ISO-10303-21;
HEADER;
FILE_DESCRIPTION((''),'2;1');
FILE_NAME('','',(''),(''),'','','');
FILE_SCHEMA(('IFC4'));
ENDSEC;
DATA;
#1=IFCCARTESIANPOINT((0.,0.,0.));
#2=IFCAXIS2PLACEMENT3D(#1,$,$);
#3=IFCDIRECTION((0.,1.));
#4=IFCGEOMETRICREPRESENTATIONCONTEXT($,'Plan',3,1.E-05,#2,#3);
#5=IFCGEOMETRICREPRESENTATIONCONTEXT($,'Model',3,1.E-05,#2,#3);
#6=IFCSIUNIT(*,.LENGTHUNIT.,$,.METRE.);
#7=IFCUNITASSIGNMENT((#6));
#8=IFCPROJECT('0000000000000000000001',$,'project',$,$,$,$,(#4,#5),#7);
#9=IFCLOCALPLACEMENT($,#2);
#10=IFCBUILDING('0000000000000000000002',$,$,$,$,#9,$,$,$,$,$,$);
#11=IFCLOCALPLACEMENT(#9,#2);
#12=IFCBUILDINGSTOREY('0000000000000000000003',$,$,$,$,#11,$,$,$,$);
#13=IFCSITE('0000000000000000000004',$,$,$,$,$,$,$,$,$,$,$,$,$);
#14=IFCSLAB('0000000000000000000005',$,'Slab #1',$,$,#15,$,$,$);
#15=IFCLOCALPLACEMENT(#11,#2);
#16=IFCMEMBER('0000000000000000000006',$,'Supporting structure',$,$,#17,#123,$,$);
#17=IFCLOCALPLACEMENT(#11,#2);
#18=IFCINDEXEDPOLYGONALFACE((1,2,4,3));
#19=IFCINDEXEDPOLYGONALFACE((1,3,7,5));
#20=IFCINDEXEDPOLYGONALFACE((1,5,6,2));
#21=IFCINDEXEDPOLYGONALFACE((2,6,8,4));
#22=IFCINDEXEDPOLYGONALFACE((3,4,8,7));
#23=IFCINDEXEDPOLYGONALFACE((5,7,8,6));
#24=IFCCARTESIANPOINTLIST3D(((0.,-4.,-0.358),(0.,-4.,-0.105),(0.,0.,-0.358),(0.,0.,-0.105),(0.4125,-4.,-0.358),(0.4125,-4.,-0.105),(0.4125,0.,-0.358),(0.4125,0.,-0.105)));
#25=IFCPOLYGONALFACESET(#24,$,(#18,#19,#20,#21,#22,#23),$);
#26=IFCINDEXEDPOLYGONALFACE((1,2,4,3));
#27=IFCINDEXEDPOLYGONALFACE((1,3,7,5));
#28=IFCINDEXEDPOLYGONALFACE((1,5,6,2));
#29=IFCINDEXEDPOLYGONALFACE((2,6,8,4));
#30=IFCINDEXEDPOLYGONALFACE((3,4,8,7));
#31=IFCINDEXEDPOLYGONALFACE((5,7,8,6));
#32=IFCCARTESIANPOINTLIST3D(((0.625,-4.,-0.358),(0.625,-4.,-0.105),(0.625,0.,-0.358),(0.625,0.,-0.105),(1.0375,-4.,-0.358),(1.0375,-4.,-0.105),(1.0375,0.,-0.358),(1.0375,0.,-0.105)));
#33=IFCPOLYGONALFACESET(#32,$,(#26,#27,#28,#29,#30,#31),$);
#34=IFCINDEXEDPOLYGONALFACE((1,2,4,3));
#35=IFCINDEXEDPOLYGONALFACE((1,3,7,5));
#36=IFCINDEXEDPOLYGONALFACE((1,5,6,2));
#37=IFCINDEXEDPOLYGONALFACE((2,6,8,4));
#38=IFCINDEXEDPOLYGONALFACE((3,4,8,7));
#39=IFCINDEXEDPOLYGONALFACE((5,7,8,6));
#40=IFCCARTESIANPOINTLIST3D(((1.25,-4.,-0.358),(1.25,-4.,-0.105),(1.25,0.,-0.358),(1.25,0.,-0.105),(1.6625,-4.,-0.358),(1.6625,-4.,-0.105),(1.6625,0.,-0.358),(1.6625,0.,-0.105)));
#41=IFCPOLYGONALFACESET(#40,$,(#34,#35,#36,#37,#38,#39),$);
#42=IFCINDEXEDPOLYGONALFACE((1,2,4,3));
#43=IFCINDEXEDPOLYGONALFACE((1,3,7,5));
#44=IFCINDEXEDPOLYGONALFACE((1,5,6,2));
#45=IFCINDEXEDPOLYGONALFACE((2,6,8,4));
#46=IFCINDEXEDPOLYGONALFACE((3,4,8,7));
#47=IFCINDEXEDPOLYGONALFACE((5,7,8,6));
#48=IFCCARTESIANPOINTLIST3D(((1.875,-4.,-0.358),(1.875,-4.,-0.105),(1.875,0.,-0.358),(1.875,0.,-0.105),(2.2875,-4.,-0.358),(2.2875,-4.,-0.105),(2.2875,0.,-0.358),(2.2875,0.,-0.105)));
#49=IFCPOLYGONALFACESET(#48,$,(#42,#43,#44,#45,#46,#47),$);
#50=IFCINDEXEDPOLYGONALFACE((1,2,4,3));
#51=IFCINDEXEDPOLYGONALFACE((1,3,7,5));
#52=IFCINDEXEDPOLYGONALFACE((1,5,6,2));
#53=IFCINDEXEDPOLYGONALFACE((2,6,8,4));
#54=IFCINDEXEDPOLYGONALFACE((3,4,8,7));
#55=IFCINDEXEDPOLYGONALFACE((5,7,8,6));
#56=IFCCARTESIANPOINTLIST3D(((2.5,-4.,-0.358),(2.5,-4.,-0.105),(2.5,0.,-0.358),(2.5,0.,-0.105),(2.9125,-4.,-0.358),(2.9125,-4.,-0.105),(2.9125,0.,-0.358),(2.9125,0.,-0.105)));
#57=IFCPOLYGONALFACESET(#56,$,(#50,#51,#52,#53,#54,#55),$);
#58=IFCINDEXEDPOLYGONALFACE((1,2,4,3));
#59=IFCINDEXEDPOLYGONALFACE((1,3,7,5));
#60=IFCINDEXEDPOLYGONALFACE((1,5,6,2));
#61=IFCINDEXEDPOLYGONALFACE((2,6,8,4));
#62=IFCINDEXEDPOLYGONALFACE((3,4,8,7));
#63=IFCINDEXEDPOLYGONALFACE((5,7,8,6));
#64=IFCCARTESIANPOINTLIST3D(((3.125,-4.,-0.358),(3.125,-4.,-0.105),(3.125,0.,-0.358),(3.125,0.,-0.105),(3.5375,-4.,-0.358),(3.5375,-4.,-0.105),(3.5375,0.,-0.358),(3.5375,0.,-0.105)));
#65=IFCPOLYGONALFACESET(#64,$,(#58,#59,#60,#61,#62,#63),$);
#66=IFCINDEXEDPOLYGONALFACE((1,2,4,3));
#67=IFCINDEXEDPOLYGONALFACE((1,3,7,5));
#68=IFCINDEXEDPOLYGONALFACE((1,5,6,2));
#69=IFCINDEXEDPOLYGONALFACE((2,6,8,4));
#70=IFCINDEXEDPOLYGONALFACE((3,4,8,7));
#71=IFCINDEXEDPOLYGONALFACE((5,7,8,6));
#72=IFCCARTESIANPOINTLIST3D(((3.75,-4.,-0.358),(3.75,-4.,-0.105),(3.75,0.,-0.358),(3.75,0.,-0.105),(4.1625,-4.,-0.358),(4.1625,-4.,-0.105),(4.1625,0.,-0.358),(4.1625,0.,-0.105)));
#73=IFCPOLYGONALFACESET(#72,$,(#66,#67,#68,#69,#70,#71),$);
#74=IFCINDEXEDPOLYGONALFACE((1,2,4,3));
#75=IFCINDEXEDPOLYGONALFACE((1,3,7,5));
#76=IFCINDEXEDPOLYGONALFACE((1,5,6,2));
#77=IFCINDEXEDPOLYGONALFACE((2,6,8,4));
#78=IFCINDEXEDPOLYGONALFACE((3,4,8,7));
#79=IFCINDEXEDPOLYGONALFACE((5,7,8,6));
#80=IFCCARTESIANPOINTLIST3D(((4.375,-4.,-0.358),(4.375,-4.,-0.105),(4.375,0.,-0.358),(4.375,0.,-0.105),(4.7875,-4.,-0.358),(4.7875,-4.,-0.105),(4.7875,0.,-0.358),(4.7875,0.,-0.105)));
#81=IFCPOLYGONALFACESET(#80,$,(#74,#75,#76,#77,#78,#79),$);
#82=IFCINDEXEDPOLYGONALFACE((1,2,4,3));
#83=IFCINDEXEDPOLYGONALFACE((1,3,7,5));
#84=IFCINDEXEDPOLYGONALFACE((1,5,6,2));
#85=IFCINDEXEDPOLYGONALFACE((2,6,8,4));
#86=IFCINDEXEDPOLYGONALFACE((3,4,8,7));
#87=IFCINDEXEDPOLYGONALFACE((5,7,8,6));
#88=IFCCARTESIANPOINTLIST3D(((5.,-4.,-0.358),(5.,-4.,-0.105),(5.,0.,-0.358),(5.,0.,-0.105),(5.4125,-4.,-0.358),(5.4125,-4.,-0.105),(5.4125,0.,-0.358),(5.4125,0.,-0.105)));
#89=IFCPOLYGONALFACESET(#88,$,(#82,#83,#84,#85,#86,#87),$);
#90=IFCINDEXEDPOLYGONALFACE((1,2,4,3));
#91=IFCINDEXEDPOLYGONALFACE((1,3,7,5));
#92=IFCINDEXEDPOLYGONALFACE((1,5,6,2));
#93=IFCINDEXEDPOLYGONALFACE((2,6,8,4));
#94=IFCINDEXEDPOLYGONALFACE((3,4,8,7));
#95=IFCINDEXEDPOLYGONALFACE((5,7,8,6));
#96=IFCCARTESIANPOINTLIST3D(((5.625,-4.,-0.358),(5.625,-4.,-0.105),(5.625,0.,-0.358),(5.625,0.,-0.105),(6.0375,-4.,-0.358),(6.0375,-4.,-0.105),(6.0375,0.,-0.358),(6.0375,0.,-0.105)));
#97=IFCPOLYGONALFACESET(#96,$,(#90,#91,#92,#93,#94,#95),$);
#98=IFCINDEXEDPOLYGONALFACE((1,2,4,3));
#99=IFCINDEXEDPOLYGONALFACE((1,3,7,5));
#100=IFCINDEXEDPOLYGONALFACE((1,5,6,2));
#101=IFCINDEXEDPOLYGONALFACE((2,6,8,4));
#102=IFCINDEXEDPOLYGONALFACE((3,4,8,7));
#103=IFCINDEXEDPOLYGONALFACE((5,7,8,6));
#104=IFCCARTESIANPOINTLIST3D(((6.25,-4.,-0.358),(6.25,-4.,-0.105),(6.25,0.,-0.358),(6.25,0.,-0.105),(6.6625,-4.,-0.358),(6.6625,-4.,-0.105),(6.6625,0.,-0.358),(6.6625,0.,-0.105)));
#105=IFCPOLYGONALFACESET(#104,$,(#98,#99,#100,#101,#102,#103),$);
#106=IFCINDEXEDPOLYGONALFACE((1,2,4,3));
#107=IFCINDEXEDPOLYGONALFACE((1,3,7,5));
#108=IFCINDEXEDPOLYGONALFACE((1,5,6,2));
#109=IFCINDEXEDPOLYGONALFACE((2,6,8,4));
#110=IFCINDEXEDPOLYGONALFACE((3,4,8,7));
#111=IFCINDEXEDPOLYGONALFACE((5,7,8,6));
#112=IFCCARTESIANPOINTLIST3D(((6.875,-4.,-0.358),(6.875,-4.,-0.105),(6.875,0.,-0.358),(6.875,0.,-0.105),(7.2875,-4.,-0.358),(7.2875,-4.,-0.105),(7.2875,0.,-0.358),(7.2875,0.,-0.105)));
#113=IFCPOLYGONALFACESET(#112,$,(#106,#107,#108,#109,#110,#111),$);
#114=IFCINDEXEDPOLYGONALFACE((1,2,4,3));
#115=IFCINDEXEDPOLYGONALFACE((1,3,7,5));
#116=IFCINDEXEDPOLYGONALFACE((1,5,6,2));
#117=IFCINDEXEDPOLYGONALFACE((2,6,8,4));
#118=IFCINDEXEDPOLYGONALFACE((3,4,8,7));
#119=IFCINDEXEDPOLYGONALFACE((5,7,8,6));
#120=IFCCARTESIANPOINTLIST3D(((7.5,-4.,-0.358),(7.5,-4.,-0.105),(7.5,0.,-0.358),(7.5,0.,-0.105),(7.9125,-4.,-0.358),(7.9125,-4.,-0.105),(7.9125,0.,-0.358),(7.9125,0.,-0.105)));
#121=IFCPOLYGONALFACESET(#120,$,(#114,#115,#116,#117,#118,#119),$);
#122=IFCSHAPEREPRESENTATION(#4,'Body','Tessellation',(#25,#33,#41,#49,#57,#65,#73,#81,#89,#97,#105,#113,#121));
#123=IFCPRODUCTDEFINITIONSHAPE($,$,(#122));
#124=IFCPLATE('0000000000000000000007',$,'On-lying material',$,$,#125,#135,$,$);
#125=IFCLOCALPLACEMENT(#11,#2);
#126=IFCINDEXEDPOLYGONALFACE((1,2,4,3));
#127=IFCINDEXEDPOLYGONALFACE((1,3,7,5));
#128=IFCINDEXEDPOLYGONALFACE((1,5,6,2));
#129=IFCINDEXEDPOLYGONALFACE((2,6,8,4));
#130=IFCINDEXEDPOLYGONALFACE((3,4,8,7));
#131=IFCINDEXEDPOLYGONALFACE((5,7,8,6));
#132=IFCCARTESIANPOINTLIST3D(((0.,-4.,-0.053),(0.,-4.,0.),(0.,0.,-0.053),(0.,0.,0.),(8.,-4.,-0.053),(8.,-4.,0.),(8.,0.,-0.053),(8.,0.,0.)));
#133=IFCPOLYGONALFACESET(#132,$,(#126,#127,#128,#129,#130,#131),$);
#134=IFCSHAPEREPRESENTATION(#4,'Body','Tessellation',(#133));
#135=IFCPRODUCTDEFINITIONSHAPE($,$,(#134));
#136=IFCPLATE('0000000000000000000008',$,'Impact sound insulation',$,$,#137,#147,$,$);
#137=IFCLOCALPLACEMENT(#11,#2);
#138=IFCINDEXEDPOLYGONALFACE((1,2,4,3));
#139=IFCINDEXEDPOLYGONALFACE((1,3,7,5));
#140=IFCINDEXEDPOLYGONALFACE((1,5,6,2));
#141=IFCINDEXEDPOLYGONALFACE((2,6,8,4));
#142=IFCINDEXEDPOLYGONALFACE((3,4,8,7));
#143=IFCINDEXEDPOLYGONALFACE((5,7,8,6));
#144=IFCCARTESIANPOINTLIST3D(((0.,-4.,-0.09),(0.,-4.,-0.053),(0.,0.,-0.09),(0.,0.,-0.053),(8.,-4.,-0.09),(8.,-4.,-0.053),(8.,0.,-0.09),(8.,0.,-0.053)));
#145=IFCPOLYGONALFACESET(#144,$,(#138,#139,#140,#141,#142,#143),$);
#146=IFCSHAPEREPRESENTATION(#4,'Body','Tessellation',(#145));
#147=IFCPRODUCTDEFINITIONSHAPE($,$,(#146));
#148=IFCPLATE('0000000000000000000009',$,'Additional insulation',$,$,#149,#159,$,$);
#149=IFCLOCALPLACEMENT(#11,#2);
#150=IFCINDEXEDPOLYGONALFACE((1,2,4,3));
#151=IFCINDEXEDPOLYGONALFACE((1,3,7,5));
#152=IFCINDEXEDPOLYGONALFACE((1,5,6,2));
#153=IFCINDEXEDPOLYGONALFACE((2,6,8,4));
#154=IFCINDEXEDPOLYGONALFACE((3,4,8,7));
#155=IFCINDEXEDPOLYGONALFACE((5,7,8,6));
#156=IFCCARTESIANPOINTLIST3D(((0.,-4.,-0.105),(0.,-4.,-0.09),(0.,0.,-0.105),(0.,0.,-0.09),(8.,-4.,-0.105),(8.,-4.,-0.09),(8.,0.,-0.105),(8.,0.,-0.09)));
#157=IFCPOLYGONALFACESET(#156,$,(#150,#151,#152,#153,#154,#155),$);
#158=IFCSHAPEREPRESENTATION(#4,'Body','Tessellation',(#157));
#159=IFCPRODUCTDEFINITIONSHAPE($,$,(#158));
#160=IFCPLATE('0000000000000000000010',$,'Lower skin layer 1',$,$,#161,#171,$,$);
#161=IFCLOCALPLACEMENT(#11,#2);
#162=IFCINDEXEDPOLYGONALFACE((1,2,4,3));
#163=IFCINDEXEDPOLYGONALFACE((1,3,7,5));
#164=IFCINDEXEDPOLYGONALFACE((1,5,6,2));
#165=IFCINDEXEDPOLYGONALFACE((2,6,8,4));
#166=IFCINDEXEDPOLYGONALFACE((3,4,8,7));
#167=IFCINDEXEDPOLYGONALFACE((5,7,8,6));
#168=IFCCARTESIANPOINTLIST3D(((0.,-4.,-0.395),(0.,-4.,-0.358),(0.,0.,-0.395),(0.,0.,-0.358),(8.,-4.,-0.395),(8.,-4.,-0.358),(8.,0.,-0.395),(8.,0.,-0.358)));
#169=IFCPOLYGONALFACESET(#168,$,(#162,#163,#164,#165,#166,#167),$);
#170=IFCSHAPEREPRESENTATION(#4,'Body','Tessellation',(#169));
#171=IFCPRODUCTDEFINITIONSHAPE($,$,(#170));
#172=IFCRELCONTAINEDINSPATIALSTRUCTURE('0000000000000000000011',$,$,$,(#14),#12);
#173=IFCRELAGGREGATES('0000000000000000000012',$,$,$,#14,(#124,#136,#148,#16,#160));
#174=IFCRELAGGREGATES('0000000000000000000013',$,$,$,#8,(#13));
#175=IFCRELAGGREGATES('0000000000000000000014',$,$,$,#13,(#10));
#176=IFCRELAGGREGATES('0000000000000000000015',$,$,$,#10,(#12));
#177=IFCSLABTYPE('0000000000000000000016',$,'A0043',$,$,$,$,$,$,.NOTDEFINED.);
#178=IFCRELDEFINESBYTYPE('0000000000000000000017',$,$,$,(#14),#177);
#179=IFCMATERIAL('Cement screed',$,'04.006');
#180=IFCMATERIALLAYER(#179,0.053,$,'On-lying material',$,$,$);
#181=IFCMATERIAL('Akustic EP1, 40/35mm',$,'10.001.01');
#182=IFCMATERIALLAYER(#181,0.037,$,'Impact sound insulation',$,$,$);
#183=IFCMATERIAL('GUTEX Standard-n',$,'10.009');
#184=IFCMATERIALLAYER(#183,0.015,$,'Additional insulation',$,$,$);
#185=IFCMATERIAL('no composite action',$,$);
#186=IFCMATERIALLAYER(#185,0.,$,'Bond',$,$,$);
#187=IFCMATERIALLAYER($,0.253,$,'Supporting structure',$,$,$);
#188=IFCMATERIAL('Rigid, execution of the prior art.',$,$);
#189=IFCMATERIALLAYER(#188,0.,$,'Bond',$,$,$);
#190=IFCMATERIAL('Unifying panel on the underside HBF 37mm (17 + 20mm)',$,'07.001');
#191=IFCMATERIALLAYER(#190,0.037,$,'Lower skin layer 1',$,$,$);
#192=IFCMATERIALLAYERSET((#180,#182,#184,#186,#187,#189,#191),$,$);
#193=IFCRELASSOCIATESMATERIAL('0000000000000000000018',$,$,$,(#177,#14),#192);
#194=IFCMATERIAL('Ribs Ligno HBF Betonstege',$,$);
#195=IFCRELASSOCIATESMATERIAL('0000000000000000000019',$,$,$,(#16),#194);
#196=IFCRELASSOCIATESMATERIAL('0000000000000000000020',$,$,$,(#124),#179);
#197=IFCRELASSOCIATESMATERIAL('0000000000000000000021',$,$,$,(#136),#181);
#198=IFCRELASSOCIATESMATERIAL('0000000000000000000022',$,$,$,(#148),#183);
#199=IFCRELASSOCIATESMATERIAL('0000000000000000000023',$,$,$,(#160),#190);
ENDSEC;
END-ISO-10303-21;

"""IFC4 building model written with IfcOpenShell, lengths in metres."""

from ifc_helpers import new_model, si_unit, direction, frame, frame_2d, origin, origin_with_axes, place, context, project, spatial, rectangle, extrude, material, layer, layer_set, type_object, element, aggregate, save


model = new_model("IFC4")

# Units and contexts
plan_context = context("Plan", 3, precision=1e-05, world=origin(), true_north=direction((0.0, 1.0)))
model_context = context("Model", 3, precision=1e-05, world=origin(), true_north=direction((0.0, 1.0)))
ifc_project = project(units=[si_unit("LENGTHUNIT", "METRE")], contexts=[plan_context, model_context])

# Site, building, storey
site = spatial("IfcSite", under=ifc_project)
building_placement = place(None, origin())
building = spatial("IfcBuilding", under=site, at=building_placement)
storey_placement = place(building_placement, origin())
storey = spatial("IfcBuildingStorey", under=building, at=storey_placement)

# Slab, member, plates
ifc_material_1 = material(Name="Cement screed", Category="04.006")
ifc_layer_1 = layer(ifc_material_1, 0.053, Name="On-lying material")
ifc_material_2 = material(Name="Akustic EP1, 40/35mm", Category="10.001.01")
ifc_layer_2 = layer(ifc_material_2, 0.037, Name="Impact sound insulation")
ifc_material_3 = material(Name="GUTEX Standard-n", Category="10.009")
ifc_layer_3 = layer(ifc_material_3, 0.015, Name="Additional insulation")
ifc_material_4 = material(Name="no composite action")
ifc_layer_4 = layer(ifc_material_4, 0.0, Name="Bond")
ifc_layer_5 = layer(None, 0.253, Name="Supporting structure")
ifc_material_5 = material(Name="Rigid, execution of the prior art.")
ifc_layer_6 = layer(ifc_material_5, 0.0, Name="Bond")
ifc_material_6 = material(Name="Unifying panel on the underside HBF 37mm (17 + 20mm)", Category="07.001")
ifc_layer_7 = layer(ifc_material_6, 0.037, Name="Lower skin layer 1")
ifc_layer_set = layer_set([ifc_layer_1, ifc_layer_2, ifc_layer_3, ifc_layer_4, ifc_layer_5, ifc_layer_6, ifc_layer_7])
slab_type = type_object("IfcSlabType", Name="A0043", PredefinedType="NOTDEFINED", material=ifc_layer_set)
slab_placement = place(None, frame((0.0, 0.0, 0.0), z_axis=(0.0, 0.0, -1.0), x_axis=(1.0, 0.0, 0.0)))
slab = element("IfcSlab", 1, at=slab_placement, inside=storey, type_object=slab_type, material=ifc_layer_set, Name="Slab #1")
ifc_material_7 = material(Name="Ribs Ligno HBF Betonstege")
member_placement = place(slab_placement, origin())
member = element("IfcMember", 2, at=member_placement, material=ifc_material_7, Name="Supporting structure", context=plan_context, shape_type="SweptSolid", body=[
    extrude(rectangle(XDim=0.4125, YDim=0.253, at=frame_2d((0.2062, 0.1265), x_axis=(1.0, 0.0))), frame((0.0, 4.0, 0.105), z_axis=(0.0, -1.0, 0.0), x_axis=(1.0, 0.0, 0.0)), (0.0, 0.0, 1.0), 4.0),
    extrude(rectangle(XDim=0.4125, YDim=0.253, at=frame_2d((0.2062, 0.1265), x_axis=(1.0, 0.0))), frame((0.625, 4.0, 0.105), z_axis=(0.0, -1.0, 0.0), x_axis=(1.0, 0.0, 0.0)), (0.0, 0.0, 1.0), 4.0),
    extrude(rectangle(XDim=0.4125, YDim=0.253, at=frame_2d((0.2062, 0.1265), x_axis=(1.0, 0.0))), frame((1.25, 4.0, 0.105), z_axis=(0.0, -1.0, 0.0), x_axis=(1.0, 0.0, 0.0)), (0.0, 0.0, 1.0), 4.0),
    extrude(rectangle(XDim=0.4125, YDim=0.253, at=frame_2d((0.2062, 0.1265), x_axis=(1.0, 0.0))), frame((1.875, 4.0, 0.105), z_axis=(0.0, -1.0, 0.0), x_axis=(1.0, 0.0, 0.0)), (0.0, 0.0, 1.0), 4.0),
    extrude(rectangle(XDim=0.4125, YDim=0.253, at=frame_2d((0.2062, 0.1265), x_axis=(1.0, 0.0))), frame((2.5, 4.0, 0.105), z_axis=(0.0, -1.0, 0.0), x_axis=(1.0, 0.0, 0.0)), (0.0, 0.0, 1.0), 4.0),
    extrude(rectangle(XDim=0.4125, YDim=0.253, at=frame_2d((0.2062, 0.1265), x_axis=(1.0, 0.0))), frame((3.125, 4.0, 0.105), z_axis=(0.0, -1.0, 0.0), x_axis=(1.0, 0.0, 0.0)), (0.0, 0.0, 1.0), 4.0),
    extrude(rectangle(XDim=0.4125, YDim=0.253, at=frame_2d((0.2062, 0.1265), x_axis=(1.0, 0.0))), frame((3.75, 4.0, 0.105), z_axis=(0.0, -1.0, 0.0), x_axis=(1.0, 0.0, 0.0)), (0.0, 0.0, 1.0), 4.0),
    extrude(rectangle(XDim=0.4125, YDim=0.253, at=frame_2d((0.2062, 0.1265), x_axis=(1.0, 0.0))), frame((4.375, 4.0, 0.105), z_axis=(0.0, -1.0, 0.0), x_axis=(1.0, 0.0, 0.0)), (0.0, 0.0, 1.0), 4.0),
    extrude(rectangle(XDim=0.4125, YDim=0.253, at=frame_2d((0.2062, 0.1265), x_axis=(1.0, 0.0))), frame((5.0, 4.0, 0.105), z_axis=(0.0, -1.0, 0.0), x_axis=(1.0, 0.0, 0.0)), (0.0, 0.0, 1.0), 4.0),
    extrude(rectangle(XDim=0.4125, YDim=0.253, at=frame_2d((0.2062, 0.1265), x_axis=(1.0, 0.0))), frame((5.625, 4.0, 0.105), z_axis=(0.0, -1.0, 0.0), x_axis=(1.0, 0.0, 0.0)), (0.0, 0.0, 1.0), 4.0),
    extrude(rectangle(XDim=0.4125, YDim=0.253, at=frame_2d((0.2062, 0.1265), x_axis=(1.0, 0.0))), frame((6.25, 4.0, 0.105), z_axis=(0.0, -1.0, 0.0), x_axis=(1.0, 0.0, 0.0)), (0.0, 0.0, 1.0), 4.0),
    extrude(rectangle(XDim=0.4125, YDim=0.253, at=frame_2d((0.2062, 0.1265), x_axis=(1.0, 0.0))), frame((6.875, 4.0, 0.105), z_axis=(0.0, -1.0, 0.0), x_axis=(1.0, 0.0, 0.0)), (0.0, 0.0, 1.0), 4.0),
    extrude(rectangle(XDim=0.4125, YDim=0.253, at=frame_2d((0.2062, 0.1265), x_axis=(1.0, 0.0))), frame((7.5, 4.0, 0.105), z_axis=(0.0, -1.0, 0.0), x_axis=(1.0, 0.0, 0.0)), (0.0, 0.0, 1.0), 4.0),
])
plate_1_placement = place(slab_placement, origin())
plate_1 = element("IfcPlate", 3, at=plate_1_placement, material=ifc_material_1, Name="On-lying material", context=plan_context, shape_type="SweptSolid", body=[
    extrude(rectangle(XDim=8.0, YDim=4.0, at=frame_2d((4.0, 2.0), x_axis=(1.0, 0.0))), origin_with_axes(), (0.0, 0.0, 1.0), 0.053),
])
plate_2_placement = place(slab_placement, origin())
plate_2 = element("IfcPlate", 4, at=plate_2_placement, material=ifc_material_2, Name="Impact sound insulation", context=plan_context, shape_type="SweptSolid", body=[
    extrude(rectangle(XDim=8.0, YDim=4.0, at=frame_2d((4.0, 2.0), x_axis=(1.0, 0.0))), frame((0.0, 0.0, 0.053), z_axis=(0.0, 0.0, 1.0), x_axis=(1.0, 0.0, 0.0)), (0.0, 0.0, 1.0), 0.037),
])
plate_3_placement = place(slab_placement, origin())
plate_3 = element("IfcPlate", 5, at=plate_3_placement, material=ifc_material_3, Name="Additional insulation", context=plan_context, shape_type="SweptSolid", body=[
    extrude(rectangle(XDim=8.0, YDim=4.0, at=frame_2d((4.0, 2.0), x_axis=(1.0, 0.0))), frame((0.0, 0.0, 0.09), z_axis=(0.0, 0.0, 1.0), x_axis=(1.0, 0.0, 0.0)), (0.0, 0.0, 1.0), 0.015),
])
plate_4_placement = place(slab_placement, origin())
plate_4 = element("IfcPlate", 6, at=plate_4_placement, material=ifc_material_6, Name="Lower skin layer 1", context=plan_context, shape_type="SweptSolid", body=[
    extrude(rectangle(XDim=8.0, YDim=4.0, at=frame_2d((4.0, 2.0), x_axis=(1.0, 0.0))), frame((0.0, 0.0, 0.358), z_axis=(0.0, 0.0, 1.0), x_axis=(1.0, 0.0, 0.0)), (0.0, 0.0, 1.0), 0.037),
])
aggregate(slab, [plate_1, plate_2, plate_3, member, plate_4])

save(model, "model.ifc")
